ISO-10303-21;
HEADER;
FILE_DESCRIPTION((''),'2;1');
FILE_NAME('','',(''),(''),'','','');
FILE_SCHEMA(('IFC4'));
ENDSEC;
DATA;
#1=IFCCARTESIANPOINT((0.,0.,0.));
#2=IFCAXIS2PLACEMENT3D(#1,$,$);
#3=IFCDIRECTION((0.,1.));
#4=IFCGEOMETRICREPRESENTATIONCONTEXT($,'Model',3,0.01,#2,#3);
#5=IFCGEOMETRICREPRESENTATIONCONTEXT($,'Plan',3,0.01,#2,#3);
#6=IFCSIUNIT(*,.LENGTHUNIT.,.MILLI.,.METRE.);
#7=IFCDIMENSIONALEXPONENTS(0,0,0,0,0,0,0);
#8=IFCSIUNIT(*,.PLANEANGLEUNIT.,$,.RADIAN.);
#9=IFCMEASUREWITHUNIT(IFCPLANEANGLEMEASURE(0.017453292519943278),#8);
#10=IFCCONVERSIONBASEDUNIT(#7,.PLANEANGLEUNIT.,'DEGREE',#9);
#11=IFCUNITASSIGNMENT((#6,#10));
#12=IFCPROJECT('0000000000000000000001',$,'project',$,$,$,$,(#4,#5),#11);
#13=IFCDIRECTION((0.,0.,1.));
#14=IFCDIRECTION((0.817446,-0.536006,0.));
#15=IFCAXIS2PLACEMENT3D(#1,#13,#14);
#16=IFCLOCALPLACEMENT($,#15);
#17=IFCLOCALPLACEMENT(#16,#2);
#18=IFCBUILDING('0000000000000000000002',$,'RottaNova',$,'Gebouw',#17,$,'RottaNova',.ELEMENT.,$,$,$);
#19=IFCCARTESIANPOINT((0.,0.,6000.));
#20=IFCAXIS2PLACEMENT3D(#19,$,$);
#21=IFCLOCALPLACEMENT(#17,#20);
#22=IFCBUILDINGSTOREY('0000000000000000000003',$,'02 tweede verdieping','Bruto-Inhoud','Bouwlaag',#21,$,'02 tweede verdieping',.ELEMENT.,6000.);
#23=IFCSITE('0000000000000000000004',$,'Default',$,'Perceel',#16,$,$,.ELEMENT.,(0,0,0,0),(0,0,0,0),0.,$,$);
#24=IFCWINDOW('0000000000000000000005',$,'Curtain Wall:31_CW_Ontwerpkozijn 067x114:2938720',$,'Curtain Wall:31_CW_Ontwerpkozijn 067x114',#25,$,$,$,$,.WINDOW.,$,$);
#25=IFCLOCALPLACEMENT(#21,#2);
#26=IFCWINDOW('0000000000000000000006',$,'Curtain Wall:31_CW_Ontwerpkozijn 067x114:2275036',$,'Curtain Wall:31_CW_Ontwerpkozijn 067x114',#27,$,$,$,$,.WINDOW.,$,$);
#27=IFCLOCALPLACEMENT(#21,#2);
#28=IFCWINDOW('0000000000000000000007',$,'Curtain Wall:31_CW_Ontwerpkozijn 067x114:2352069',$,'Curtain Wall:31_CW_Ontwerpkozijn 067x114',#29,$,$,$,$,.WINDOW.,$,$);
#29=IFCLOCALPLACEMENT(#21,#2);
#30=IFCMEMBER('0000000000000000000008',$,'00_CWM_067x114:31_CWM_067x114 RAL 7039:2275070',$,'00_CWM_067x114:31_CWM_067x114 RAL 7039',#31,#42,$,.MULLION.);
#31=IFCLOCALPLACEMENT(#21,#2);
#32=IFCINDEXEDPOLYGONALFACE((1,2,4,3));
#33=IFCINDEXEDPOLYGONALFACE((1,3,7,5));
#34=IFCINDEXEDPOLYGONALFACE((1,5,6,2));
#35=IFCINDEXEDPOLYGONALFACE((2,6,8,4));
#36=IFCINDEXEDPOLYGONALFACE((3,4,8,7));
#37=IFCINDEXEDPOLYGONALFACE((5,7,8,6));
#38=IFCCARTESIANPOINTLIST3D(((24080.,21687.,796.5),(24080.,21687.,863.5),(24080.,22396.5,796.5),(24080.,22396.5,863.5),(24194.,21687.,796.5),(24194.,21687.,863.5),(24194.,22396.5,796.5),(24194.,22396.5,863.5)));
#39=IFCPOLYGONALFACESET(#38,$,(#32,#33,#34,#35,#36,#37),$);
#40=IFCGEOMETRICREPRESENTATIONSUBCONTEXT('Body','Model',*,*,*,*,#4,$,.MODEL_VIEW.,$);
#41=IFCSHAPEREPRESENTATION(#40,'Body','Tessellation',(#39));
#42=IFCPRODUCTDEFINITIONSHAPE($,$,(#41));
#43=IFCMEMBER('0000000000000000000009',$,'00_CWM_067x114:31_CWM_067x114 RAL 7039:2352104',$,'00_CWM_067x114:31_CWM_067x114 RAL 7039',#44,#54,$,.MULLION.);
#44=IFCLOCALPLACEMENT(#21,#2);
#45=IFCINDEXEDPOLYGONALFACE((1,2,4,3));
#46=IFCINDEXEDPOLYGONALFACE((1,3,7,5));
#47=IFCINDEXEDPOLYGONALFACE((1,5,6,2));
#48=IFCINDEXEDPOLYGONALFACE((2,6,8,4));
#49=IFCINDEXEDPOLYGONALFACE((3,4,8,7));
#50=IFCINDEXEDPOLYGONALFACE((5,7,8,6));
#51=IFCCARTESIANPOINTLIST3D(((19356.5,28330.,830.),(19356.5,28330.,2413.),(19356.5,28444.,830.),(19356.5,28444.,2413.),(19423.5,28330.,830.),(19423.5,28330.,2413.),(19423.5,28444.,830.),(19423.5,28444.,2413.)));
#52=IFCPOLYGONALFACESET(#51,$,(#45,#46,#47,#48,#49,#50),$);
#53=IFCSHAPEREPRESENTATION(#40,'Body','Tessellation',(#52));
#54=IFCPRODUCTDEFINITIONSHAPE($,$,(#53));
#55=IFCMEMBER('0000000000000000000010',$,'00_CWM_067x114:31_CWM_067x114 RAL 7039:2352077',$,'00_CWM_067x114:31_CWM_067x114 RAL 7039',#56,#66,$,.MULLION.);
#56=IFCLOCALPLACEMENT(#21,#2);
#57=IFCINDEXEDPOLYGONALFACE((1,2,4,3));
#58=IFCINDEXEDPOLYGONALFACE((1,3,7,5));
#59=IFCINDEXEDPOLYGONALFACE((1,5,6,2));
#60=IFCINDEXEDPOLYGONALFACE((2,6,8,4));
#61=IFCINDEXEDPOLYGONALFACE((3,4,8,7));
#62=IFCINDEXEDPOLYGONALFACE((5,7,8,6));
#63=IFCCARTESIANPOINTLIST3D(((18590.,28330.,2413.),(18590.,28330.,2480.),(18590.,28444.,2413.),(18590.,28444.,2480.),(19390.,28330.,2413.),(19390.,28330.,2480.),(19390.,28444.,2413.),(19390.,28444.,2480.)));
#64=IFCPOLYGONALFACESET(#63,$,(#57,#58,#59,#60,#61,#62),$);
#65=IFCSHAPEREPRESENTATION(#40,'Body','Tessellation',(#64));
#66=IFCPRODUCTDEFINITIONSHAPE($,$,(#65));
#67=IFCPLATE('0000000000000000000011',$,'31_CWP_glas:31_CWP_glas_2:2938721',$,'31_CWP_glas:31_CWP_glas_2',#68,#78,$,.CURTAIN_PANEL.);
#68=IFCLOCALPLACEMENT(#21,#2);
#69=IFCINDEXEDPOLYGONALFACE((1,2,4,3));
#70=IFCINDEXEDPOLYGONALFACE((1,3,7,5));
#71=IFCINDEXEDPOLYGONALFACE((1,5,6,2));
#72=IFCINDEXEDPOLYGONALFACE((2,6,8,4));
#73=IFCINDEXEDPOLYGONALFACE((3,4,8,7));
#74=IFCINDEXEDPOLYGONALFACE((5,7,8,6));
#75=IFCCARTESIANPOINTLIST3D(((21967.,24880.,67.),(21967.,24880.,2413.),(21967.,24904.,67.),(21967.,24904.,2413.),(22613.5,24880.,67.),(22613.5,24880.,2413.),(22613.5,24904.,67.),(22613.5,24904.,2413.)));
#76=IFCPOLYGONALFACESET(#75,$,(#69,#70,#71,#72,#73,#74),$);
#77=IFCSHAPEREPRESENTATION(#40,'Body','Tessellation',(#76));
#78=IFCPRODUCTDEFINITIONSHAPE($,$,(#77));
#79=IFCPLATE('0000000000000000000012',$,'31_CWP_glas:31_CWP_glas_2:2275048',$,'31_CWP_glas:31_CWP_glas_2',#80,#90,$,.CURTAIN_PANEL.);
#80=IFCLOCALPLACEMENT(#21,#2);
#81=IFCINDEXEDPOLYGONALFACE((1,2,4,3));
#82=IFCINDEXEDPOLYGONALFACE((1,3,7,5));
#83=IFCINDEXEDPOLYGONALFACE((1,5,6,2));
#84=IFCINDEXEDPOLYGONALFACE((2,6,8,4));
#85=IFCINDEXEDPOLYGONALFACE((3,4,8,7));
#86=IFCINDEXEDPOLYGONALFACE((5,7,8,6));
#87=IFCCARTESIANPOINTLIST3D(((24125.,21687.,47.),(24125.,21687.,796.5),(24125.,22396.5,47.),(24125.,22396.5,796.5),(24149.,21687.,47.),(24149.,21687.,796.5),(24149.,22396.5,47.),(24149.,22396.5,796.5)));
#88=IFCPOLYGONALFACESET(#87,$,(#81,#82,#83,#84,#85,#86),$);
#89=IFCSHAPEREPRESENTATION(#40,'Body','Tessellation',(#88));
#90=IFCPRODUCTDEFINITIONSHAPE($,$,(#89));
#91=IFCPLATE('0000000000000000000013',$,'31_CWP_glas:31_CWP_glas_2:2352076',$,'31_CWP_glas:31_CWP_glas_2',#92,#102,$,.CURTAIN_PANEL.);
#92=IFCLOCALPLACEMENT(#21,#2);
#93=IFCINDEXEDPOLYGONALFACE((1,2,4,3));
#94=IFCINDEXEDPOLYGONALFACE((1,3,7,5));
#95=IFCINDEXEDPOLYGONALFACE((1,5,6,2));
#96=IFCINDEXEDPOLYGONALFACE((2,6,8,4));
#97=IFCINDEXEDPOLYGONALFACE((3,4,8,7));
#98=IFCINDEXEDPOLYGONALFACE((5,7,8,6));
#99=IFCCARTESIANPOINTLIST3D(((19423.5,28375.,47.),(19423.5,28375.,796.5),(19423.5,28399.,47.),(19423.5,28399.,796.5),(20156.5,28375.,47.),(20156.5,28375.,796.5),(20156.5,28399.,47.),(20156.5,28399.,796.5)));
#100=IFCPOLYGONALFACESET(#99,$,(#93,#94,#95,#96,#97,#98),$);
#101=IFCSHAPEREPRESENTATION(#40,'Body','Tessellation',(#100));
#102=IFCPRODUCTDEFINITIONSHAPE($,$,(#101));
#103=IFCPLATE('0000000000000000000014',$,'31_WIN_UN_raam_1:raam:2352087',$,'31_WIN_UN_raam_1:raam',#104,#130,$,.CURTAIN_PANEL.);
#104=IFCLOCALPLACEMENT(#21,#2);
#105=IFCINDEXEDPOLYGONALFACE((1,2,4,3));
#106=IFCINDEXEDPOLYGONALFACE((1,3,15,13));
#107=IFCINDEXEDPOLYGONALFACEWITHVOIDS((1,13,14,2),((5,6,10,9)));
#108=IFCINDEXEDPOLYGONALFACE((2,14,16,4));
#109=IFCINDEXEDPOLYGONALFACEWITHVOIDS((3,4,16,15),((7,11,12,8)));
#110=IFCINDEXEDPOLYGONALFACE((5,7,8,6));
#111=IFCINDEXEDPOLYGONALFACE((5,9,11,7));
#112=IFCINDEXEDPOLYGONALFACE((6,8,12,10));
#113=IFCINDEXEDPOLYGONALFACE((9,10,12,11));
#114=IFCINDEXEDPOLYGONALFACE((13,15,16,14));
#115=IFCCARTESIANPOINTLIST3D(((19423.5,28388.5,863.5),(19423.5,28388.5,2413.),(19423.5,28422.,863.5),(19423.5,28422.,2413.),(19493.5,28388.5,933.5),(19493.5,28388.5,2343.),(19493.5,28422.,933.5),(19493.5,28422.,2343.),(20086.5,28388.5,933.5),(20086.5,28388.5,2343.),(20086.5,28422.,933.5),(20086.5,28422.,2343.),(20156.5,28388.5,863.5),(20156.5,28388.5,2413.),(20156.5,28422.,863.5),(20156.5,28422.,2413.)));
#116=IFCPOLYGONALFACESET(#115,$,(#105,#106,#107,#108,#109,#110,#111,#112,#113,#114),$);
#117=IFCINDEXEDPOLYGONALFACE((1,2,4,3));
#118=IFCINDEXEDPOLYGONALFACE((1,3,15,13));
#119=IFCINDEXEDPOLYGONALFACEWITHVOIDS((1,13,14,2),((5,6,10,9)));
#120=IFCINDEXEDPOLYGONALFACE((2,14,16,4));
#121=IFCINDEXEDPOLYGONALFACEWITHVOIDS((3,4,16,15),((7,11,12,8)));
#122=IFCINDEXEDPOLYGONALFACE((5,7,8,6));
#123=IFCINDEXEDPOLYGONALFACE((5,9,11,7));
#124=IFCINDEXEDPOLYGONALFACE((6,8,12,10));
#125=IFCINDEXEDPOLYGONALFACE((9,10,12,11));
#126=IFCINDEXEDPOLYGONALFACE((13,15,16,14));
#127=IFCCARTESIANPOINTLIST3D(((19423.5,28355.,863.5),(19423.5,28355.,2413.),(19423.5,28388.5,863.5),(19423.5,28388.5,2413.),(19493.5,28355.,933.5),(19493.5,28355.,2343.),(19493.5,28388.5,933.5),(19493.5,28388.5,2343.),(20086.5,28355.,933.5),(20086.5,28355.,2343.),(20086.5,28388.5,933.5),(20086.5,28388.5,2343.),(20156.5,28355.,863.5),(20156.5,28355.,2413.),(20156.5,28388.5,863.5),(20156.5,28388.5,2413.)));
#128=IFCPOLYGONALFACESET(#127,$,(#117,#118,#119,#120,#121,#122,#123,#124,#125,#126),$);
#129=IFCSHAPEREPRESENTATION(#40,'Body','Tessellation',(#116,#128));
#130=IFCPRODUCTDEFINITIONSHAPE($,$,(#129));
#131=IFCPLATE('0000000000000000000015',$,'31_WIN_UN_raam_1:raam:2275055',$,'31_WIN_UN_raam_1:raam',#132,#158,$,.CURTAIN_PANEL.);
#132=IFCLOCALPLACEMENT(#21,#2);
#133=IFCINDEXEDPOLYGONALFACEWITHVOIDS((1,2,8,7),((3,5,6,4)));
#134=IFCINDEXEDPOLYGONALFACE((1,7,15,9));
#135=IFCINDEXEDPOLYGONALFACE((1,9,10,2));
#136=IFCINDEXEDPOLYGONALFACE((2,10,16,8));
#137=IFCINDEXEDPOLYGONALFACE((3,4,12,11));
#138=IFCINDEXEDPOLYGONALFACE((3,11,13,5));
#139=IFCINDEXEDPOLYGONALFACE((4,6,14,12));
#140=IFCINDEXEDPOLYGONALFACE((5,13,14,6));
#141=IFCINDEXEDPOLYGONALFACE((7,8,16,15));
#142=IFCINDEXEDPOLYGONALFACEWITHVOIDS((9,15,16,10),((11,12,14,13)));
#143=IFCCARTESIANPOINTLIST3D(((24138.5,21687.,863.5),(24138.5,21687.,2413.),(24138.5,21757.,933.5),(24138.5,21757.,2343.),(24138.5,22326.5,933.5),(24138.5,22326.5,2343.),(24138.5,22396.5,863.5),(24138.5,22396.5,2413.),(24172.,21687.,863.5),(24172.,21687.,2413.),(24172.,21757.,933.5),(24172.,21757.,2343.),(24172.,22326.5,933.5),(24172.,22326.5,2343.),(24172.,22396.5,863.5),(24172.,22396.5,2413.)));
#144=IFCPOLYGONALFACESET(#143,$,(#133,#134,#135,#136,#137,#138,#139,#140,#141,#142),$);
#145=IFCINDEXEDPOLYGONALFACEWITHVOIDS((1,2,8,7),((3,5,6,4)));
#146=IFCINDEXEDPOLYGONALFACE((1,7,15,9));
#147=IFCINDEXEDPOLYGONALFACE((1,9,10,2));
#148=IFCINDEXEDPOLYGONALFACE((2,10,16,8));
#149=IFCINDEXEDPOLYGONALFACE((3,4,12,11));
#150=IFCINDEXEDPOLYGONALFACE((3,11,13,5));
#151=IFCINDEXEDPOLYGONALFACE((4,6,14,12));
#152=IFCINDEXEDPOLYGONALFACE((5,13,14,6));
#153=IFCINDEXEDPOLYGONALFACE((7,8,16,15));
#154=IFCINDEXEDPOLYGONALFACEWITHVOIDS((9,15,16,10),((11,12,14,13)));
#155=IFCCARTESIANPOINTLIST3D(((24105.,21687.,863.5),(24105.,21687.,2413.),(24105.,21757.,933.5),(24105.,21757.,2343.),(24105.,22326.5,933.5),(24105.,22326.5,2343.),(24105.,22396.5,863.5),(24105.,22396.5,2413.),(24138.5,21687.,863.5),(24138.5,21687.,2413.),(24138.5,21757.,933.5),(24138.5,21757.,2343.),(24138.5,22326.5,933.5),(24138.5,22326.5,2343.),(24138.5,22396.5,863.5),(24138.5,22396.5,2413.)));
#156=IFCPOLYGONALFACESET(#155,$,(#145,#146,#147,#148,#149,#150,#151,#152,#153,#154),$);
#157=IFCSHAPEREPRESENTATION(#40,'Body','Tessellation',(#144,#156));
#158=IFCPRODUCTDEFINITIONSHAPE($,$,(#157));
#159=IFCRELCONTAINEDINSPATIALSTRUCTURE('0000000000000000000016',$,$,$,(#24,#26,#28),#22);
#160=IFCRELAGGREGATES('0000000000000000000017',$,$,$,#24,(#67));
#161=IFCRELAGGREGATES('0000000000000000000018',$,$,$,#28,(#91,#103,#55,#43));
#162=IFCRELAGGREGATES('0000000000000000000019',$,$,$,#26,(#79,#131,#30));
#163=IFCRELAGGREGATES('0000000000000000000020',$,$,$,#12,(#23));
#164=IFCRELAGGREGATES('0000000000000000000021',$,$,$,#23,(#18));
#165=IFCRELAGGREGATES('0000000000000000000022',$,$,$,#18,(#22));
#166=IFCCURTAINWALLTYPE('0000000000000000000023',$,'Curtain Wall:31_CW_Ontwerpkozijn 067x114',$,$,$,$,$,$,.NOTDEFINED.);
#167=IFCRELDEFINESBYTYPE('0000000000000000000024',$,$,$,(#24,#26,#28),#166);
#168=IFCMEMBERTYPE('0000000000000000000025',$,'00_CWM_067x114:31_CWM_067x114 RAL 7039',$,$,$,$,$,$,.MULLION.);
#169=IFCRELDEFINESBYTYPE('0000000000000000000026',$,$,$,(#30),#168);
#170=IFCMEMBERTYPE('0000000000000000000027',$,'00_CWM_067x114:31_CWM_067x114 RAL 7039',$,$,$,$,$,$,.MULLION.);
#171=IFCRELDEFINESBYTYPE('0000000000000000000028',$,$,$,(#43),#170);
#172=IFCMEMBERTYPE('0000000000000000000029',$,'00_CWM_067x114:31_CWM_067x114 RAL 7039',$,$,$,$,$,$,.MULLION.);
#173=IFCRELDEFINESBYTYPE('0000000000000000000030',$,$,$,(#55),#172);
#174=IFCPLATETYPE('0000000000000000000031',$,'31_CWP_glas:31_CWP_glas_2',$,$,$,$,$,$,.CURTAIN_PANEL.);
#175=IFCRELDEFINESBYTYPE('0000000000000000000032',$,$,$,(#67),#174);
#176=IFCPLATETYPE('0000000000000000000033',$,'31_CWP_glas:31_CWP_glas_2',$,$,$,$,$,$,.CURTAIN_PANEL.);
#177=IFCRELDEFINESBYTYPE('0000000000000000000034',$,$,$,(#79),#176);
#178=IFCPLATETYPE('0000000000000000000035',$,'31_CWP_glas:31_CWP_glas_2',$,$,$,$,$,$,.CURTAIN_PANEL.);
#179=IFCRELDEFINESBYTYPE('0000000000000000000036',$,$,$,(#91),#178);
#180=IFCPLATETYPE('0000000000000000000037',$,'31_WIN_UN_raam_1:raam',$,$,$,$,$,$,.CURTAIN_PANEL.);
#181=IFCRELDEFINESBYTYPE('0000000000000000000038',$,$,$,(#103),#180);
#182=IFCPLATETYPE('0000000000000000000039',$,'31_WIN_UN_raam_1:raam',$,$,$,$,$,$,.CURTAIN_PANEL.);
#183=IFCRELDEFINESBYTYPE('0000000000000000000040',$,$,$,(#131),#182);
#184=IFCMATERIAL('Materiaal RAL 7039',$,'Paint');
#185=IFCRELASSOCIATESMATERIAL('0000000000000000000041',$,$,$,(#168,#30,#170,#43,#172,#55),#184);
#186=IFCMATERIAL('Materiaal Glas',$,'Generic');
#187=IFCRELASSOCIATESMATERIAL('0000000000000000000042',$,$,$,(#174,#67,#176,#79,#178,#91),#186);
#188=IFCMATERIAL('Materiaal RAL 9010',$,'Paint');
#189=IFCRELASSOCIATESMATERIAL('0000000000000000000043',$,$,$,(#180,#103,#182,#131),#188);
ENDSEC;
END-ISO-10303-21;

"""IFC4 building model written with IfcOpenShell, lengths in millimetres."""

from ifc_helpers import new_model, entity, si_unit, converted_unit, direction, frame, origin, place, context, subcontext, project, spatial, indexed_curve, outline, extrude, source, transform, mapped, material, type_object, type_shapes, element, aggregate, save


model = new_model("IFC4")

# Units and contexts
model_context = context("Model", 3, precision=0.01, world=origin(), true_north=direction((0.0, 1.0)))
plan_context = context("Plan", 3, precision=0.01, world=origin(), true_north=direction((0.0, 1.0)))
body_context = subcontext(model_context, "Body", "Model", "MODEL_VIEW")
ifc_project = project(units=[si_unit("LENGTHUNIT", "METRE", prefix="MILLI"), converted_unit("PLANEANGLEUNIT", "DEGREE", entity("IfcPlaneAngleMeasure", 0.017453292519943278), si_unit("PLANEANGLEUNIT", "RADIAN"), dimensions=[0, 0, 0, 0, 0, 0, 0])], contexts=[model_context, plan_context])

# Site, building, storey
site_placement = place(None, frame((0.0, 0.0, 0.0), z_axis=(0.0, 0.0, 1.0), x_axis=(0.817446, -0.536006, 0.0)))
site = spatial("IfcSite", under=ifc_project, at=site_placement, Name="Default", ObjectType="Perceel", CompositionType="ELEMENT", RefLatitude=(0, 0, 0, 0), RefLongitude=(0, 0, 0, 0), RefElevation=0.0)
building_placement = place(site_placement, origin())
building = spatial("IfcBuilding", under=site, at=building_placement, Name="RottaNova", ObjectType="Gebouw", LongName="RottaNova", CompositionType="ELEMENT")
storey_placement = place(building_placement, frame((0.0, 0.0, 6000.0)))
storey = spatial("IfcBuildingStorey", under=building, at=storey_placement, Name="02 tweede verdieping", Description="Bruto-Inhoud", ObjectType="Bouwlaag", LongName="02 tweede verdieping", CompositionType="ELEMENT", Elevation=6000.0)

# Shared definitions
curtain_wall_type = type_object("IfcCurtainWallType", Name="Curtain Wall:31_CW_Ontwerpkozijn 067x114", PredefinedType="NOTDEFINED")
ifc_material_1 = material(Name="Materiaal RAL 7039", Category="Paint")

# Window
window_1_placement = place(storey_placement, frame((0.0, 0.0, -6000.0)))
window_1 = element("IfcWindow", 1, at=window_1_placement, inside=storey, type_object=curtain_wall_type, Name="Curtain Wall:31_CW_Ontwerpkozijn 067x114:2938720", ObjectType="Curtain Wall:31_CW_Ontwerpkozijn 067x114", PredefinedType="WINDOW")

# Windows
window_2_placement = place(storey_placement, frame((0.0, 0.0, -6000.0)))
window_2 = element("IfcWindow", 2, at=window_2_placement, inside=storey, type_object=curtain_wall_type, Name="Curtain Wall:31_CW_Ontwerpkozijn 067x114:2275036", ObjectType="Curtain Wall:31_CW_Ontwerpkozijn 067x114", PredefinedType="WINDOW")
window_3_placement = place(storey_placement, frame((0.0, 0.0, -6000.0)))
window_3 = element("IfcWindow", 3, at=window_3_placement, inside=storey, type_object=curtain_wall_type, Name="Curtain Wall:31_CW_Ontwerpkozijn 067x114:2352069", ObjectType="Curtain Wall:31_CW_Ontwerpkozijn 067x114", PredefinedType="WINDOW")

# Members
member_type_1 = type_object("IfcMemberType", Name="00_CWM_067x114:31_CWM_067x114 RAL 7039", PredefinedType="MULLION", material=ifc_material_1)
shared_shape_1 = source(origin(), body_context, "Body", "SweptSolid", [
    extrude(outline(indexed_curve([(-33.5, -57.0), (33.5, -57.0), (33.5, 57.0), (-33.5, 57.0), (-33.5, -57.0)], self_intersect=False)), frame((0.0, -57.0, -709.5), z_axis=(0.0, 0.0, 1.0), x_axis=(-1.0, 0.0, 0.0)), (0.0, 0.0, 1.0), 709.5),
])
type_shapes(member_type_1, [shared_shape_1])
member_1_placement = place(window_2_placement, frame((24080.0, 21687.0, 6830.0), z_axis=(0.0, -1.0, 0.0), x_axis=(0.0, 0.0, 1.0)))
member_1 = element("IfcMember", 4, at=member_1_placement, type_object=member_type_1, material=ifc_material_1, Name="00_CWM_067x114:31_CWM_067x114 RAL 7039:2275070", ObjectType="00_CWM_067x114:31_CWM_067x114 RAL 7039", PredefinedType="MULLION", context=body_context, shape_type="MappedRepresentation", body=[
    mapped(shared_shape_1, transform((0.0, 0.0, 0.0), scale=1.0)),
])
member_type_2 = type_object("IfcMemberType", Name="00_CWM_067x114:31_CWM_067x114 RAL 7039", PredefinedType="MULLION", material=ifc_material_1)
shared_shape_2 = source(origin(), body_context, "Body", "SweptSolid", [
    extrude(outline(indexed_curve([(-33.5, -57.0), (33.5, -57.0), (33.5, 57.0), (-33.5, 57.0), (-33.5, -57.0)], self_intersect=False)), frame((0.0, -57.0, -1583.0), z_axis=(0.0, 0.0, 1.0), x_axis=(-1.0, 0.0, 0.0)), (0.0, 0.0, 1.0), 1583.0),
])
type_shapes(member_type_2, [shared_shape_2])
member_2_placement = place(window_3_placement, frame((19390.0, 28330.0, 6830.0), z_axis=(0.0, 0.0, -1.0), x_axis=(1.0, 0.0, 0.0)))
member_2 = element("IfcMember", 5, at=member_2_placement, type_object=member_type_2, material=ifc_material_1, Name="00_CWM_067x114:31_CWM_067x114 RAL 7039:2352104", ObjectType="00_CWM_067x114:31_CWM_067x114 RAL 7039", PredefinedType="MULLION", context=body_context, shape_type="MappedRepresentation", body=[
    mapped(shared_shape_2, transform((0.0, 0.0, 0.0), scale=1.0)),
])
member_type_3 = type_object("IfcMemberType", Name="00_CWM_067x114:31_CWM_067x114 RAL 7039", PredefinedType="MULLION", material=ifc_material_1)
shared_shape_3 = source(origin(), body_context, "Body", "SweptSolid", [
    extrude(outline(indexed_curve([(-33.5, -57.0), (33.5, -57.0), (33.5, 57.0), (-33.5, 57.0), (-33.5, -57.0)], self_intersect=False)), frame((-33.5, -57.0, -800.0), z_axis=(0.0, 0.0, 1.0), x_axis=(-1.0, 0.0, 0.0)), (0.0, 0.0, 1.0), 800.0),
])
type_shapes(member_type_3, [shared_shape_3])
member_3_placement = place(window_3_placement, frame((19390.0, 28330.0, 8480.0), z_axis=(1.0, 0.0, 0.0), x_axis=(0.0, 0.0, 1.0)))
member_3 = element("IfcMember", 6, at=member_3_placement, type_object=member_type_3, material=ifc_material_1, Name="00_CWM_067x114:31_CWM_067x114 RAL 7039:2352077", ObjectType="00_CWM_067x114:31_CWM_067x114 RAL 7039", PredefinedType="MULLION", context=body_context, shape_type="MappedRepresentation", body=[
    mapped(shared_shape_3, transform((0.0, 0.0, 0.0), scale=1.0)),
])

# Plates
ifc_material_2 = material(Name="Materiaal Glas", Category="Generic")
plate_type_1 = type_object("IfcPlateType", Name="31_CWP_glas:31_CWP_glas_2", PredefinedType="CURTAIN_PANEL", material=ifc_material_2)
shared_shape_4 = source(origin(), body_context, "Body", "SweptSolid", [
    extrude(outline(indexed_curve([(-12.0, -323.2), (12.0, -323.2), (12.0, 323.2), (-12.0, 323.2), (-12.0, -323.2)], self_intersect=False)), frame((0.0, 57.0, 0.0), z_axis=(0.0, 0.0, 1.0), x_axis=(0.0, 1.0, 0.0)), (0.0, 0.0, 1.0), 2346.0),
])
type_shapes(plate_type_1, [shared_shape_4])
plate_1_placement = place(window_1_placement, frame((22290.2, 24835.0, 6067.0)))
plate_1 = element("IfcPlate", 7, at=plate_1_placement, type_object=plate_type_1, material=ifc_material_2, Name="31_CWP_glas:31_CWP_glas_2:2938721", ObjectType="31_CWP_glas:31_CWP_glas_2", PredefinedType="CURTAIN_PANEL", context=body_context, shape_type="MappedRepresentation", body=[
    mapped(shared_shape_4, transform((0.0, 0.0, 0.0), scale=1.0)),
])
aggregate(window_1, [plate_1])
plate_type_2 = type_object("IfcPlateType", Name="31_CWP_glas:31_CWP_glas_2", PredefinedType="CURTAIN_PANEL", material=ifc_material_2)
shared_shape_5 = source(origin(), body_context, "Body", "SweptSolid", [
    extrude(outline(indexed_curve([(-12.0, -354.8), (12.0, -354.8), (12.0, 354.8), (-12.0, 354.8), (-12.0, -354.8)], self_intersect=False)), frame((0.0, 57.0, 0.0), z_axis=(0.0, 0.0, 1.0), x_axis=(0.0, 1.0, 0.0)), (0.0, 0.0, 1.0), 749.5),
])
type_shapes(plate_type_2, [shared_shape_5])
plate_2_placement = place(window_2_placement, frame((24080.0, 22041.7, 6047.0), z_axis=(0.0, 0.0, 1.0), x_axis=(0.0, -1.0, 0.0)))
plate_2 = element("IfcPlate", 8, at=plate_2_placement, type_object=plate_type_2, material=ifc_material_2, Name="31_CWP_glas:31_CWP_glas_2:2275048", ObjectType="31_CWP_glas:31_CWP_glas_2", PredefinedType="CURTAIN_PANEL", context=body_context, shape_type="MappedRepresentation", body=[
    mapped(shared_shape_5, transform((0.0, 0.0, 0.0), scale=1.0)),
])
plate_type_3 = type_object("IfcPlateType", Name="31_CWP_glas:31_CWP_glas_2", PredefinedType="CURTAIN_PANEL", material=ifc_material_2)
shared_shape_6 = source(origin(), body_context, "Body", "SweptSolid", [
    extrude(outline(indexed_curve([(-12.0, -366.5), (12.0, -366.5), (12.0, 366.5), (-12.0, 366.5), (-12.0, -366.5)], self_intersect=False)), frame((0.0, 57.0, 0.0), z_axis=(0.0, 0.0, 1.0), x_axis=(0.0, 1.0, 0.0)), (0.0, 0.0, 1.0), 749.5),
])
type_shapes(plate_type_3, [shared_shape_6])
plate_3_placement = place(window_3_placement, frame((19790.0, 28330.0, 6047.0)))
plate_3 = element("IfcPlate", 9, at=plate_3_placement, type_object=plate_type_3, material=ifc_material_2, Name="31_CWP_glas:31_CWP_glas_2:2352076", ObjectType="31_CWP_glas:31_CWP_glas_2", PredefinedType="CURTAIN_PANEL", context=body_context, shape_type="MappedRepresentation", body=[
    mapped(shared_shape_6, transform((0.0, 0.0, 0.0), scale=1.0)),
])
ifc_material_3 = material(Name="Materiaal RAL 9010", Category="Paint")
plate_type_4 = type_object("IfcPlateType", Name="31_WIN_UN_raam_1:raam", PredefinedType="CURTAIN_PANEL", material=ifc_material_3)
shared_shape_7 = source(origin(), body_context, "Body", "SweptSolid", [
    extrude(outline(indexed_curve([(-366.5, -774.8), (366.5, -774.8), (366.5, 774.8), (-366.5, 774.8), (-366.5, -774.8)], self_intersect=False), holes=[indexed_curve([(-296.5, 704.8), (296.5, 704.8), (296.5, -704.8), (-296.5, -704.8), (-296.5, 704.8)], self_intersect=False)]), frame((0.0, 58.5, 774.8), z_axis=(0.0, 1.0, 0.0), x_axis=(1.0, 0.0, 0.0)), (0.0, 0.0, 1.0), 33.5),
    extrude(outline(indexed_curve([(-366.5, -774.8), (366.5, -774.8), (366.5, 774.8), (-366.5, 774.8), (-366.5, -774.8)], self_intersect=False), holes=[indexed_curve([(-296.5, 704.7), (296.5, 704.7), (296.5, -704.8), (-296.5, -704.8), (-296.5, 704.7)], self_intersect=False)]), frame((0.0, 25.0, 774.8), z_axis=(0.0, 1.0, 0.0), x_axis=(1.0, 0.0, 0.0)), (0.0, 0.0, 1.0), 33.5),
])
type_shapes(plate_type_4, [shared_shape_7])
plate_4_placement = place(window_3_placement, frame((19790.0, 28330.0, 6863.5)))
plate_4 = element("IfcPlate", 10, at=plate_4_placement, type_object=plate_type_4, material=ifc_material_3, Name="31_WIN_UN_raam_1:raam:2352087", ObjectType="31_WIN_UN_raam_1:raam", PredefinedType="CURTAIN_PANEL", context=body_context, shape_type="MappedRepresentation", body=[
    mapped(shared_shape_7, transform((0.0, 0.0, 0.0), scale=1.0)),
])
aggregate(window_3, [plate_3, plate_4, member_3, member_2])
plate_type_5 = type_object("IfcPlateType", Name="31_WIN_UN_raam_1:raam", PredefinedType="CURTAIN_PANEL", material=ifc_material_3)
shared_shape_8 = source(origin(), body_context, "Body", "SweptSolid", [
    extrude(outline(indexed_curve([(-354.8, -774.7), (354.8, -774.7), (354.8, 774.7), (-354.8, 774.7), (-354.8, -774.7)], self_intersect=False), holes=[indexed_curve([(-284.8, 704.7), (284.8, 704.7), (284.8, -704.8), (-284.8, -704.8), (-284.8, 704.7)], self_intersect=False)]), frame((0.0, 58.5, 774.8), z_axis=(0.0, 1.0, 0.0), x_axis=(1.0, 0.0, 0.0)), (0.0, 0.0, 1.0), 33.5),
    extrude(outline(indexed_curve([(-354.8, -774.7), (354.8, -774.7), (354.8, 774.7), (-354.8, 774.7), (-354.8, -774.7)], self_intersect=False), holes=[indexed_curve([(-284.8, 704.7), (284.8, 704.7), (284.8, -704.8), (-284.8, -704.8), (-284.8, 704.7)], self_intersect=False)]), frame((0.0, 25.0, 774.8), z_axis=(0.0, 1.0, 0.0), x_axis=(1.0, 0.0, 0.0)), (0.0, 0.0, 1.0), 33.5),
])
type_shapes(plate_type_5, [shared_shape_8])
plate_5_placement = place(window_2_placement, frame((24080.0, 22041.7, 6863.5), z_axis=(0.0, 0.0, 1.0), x_axis=(0.0, -1.0, 0.0)))
plate_5 = element("IfcPlate", 11, at=plate_5_placement, type_object=plate_type_5, material=ifc_material_3, Name="31_WIN_UN_raam_1:raam:2275055", ObjectType="31_WIN_UN_raam_1:raam", PredefinedType="CURTAIN_PANEL", context=body_context, shape_type="MappedRepresentation", body=[
    mapped(shared_shape_8, transform((0.0, 0.0, 0.0), scale=1.0)),
])
aggregate(window_2, [plate_2, plate_5, member_1])

save(model, "model.ifc")
